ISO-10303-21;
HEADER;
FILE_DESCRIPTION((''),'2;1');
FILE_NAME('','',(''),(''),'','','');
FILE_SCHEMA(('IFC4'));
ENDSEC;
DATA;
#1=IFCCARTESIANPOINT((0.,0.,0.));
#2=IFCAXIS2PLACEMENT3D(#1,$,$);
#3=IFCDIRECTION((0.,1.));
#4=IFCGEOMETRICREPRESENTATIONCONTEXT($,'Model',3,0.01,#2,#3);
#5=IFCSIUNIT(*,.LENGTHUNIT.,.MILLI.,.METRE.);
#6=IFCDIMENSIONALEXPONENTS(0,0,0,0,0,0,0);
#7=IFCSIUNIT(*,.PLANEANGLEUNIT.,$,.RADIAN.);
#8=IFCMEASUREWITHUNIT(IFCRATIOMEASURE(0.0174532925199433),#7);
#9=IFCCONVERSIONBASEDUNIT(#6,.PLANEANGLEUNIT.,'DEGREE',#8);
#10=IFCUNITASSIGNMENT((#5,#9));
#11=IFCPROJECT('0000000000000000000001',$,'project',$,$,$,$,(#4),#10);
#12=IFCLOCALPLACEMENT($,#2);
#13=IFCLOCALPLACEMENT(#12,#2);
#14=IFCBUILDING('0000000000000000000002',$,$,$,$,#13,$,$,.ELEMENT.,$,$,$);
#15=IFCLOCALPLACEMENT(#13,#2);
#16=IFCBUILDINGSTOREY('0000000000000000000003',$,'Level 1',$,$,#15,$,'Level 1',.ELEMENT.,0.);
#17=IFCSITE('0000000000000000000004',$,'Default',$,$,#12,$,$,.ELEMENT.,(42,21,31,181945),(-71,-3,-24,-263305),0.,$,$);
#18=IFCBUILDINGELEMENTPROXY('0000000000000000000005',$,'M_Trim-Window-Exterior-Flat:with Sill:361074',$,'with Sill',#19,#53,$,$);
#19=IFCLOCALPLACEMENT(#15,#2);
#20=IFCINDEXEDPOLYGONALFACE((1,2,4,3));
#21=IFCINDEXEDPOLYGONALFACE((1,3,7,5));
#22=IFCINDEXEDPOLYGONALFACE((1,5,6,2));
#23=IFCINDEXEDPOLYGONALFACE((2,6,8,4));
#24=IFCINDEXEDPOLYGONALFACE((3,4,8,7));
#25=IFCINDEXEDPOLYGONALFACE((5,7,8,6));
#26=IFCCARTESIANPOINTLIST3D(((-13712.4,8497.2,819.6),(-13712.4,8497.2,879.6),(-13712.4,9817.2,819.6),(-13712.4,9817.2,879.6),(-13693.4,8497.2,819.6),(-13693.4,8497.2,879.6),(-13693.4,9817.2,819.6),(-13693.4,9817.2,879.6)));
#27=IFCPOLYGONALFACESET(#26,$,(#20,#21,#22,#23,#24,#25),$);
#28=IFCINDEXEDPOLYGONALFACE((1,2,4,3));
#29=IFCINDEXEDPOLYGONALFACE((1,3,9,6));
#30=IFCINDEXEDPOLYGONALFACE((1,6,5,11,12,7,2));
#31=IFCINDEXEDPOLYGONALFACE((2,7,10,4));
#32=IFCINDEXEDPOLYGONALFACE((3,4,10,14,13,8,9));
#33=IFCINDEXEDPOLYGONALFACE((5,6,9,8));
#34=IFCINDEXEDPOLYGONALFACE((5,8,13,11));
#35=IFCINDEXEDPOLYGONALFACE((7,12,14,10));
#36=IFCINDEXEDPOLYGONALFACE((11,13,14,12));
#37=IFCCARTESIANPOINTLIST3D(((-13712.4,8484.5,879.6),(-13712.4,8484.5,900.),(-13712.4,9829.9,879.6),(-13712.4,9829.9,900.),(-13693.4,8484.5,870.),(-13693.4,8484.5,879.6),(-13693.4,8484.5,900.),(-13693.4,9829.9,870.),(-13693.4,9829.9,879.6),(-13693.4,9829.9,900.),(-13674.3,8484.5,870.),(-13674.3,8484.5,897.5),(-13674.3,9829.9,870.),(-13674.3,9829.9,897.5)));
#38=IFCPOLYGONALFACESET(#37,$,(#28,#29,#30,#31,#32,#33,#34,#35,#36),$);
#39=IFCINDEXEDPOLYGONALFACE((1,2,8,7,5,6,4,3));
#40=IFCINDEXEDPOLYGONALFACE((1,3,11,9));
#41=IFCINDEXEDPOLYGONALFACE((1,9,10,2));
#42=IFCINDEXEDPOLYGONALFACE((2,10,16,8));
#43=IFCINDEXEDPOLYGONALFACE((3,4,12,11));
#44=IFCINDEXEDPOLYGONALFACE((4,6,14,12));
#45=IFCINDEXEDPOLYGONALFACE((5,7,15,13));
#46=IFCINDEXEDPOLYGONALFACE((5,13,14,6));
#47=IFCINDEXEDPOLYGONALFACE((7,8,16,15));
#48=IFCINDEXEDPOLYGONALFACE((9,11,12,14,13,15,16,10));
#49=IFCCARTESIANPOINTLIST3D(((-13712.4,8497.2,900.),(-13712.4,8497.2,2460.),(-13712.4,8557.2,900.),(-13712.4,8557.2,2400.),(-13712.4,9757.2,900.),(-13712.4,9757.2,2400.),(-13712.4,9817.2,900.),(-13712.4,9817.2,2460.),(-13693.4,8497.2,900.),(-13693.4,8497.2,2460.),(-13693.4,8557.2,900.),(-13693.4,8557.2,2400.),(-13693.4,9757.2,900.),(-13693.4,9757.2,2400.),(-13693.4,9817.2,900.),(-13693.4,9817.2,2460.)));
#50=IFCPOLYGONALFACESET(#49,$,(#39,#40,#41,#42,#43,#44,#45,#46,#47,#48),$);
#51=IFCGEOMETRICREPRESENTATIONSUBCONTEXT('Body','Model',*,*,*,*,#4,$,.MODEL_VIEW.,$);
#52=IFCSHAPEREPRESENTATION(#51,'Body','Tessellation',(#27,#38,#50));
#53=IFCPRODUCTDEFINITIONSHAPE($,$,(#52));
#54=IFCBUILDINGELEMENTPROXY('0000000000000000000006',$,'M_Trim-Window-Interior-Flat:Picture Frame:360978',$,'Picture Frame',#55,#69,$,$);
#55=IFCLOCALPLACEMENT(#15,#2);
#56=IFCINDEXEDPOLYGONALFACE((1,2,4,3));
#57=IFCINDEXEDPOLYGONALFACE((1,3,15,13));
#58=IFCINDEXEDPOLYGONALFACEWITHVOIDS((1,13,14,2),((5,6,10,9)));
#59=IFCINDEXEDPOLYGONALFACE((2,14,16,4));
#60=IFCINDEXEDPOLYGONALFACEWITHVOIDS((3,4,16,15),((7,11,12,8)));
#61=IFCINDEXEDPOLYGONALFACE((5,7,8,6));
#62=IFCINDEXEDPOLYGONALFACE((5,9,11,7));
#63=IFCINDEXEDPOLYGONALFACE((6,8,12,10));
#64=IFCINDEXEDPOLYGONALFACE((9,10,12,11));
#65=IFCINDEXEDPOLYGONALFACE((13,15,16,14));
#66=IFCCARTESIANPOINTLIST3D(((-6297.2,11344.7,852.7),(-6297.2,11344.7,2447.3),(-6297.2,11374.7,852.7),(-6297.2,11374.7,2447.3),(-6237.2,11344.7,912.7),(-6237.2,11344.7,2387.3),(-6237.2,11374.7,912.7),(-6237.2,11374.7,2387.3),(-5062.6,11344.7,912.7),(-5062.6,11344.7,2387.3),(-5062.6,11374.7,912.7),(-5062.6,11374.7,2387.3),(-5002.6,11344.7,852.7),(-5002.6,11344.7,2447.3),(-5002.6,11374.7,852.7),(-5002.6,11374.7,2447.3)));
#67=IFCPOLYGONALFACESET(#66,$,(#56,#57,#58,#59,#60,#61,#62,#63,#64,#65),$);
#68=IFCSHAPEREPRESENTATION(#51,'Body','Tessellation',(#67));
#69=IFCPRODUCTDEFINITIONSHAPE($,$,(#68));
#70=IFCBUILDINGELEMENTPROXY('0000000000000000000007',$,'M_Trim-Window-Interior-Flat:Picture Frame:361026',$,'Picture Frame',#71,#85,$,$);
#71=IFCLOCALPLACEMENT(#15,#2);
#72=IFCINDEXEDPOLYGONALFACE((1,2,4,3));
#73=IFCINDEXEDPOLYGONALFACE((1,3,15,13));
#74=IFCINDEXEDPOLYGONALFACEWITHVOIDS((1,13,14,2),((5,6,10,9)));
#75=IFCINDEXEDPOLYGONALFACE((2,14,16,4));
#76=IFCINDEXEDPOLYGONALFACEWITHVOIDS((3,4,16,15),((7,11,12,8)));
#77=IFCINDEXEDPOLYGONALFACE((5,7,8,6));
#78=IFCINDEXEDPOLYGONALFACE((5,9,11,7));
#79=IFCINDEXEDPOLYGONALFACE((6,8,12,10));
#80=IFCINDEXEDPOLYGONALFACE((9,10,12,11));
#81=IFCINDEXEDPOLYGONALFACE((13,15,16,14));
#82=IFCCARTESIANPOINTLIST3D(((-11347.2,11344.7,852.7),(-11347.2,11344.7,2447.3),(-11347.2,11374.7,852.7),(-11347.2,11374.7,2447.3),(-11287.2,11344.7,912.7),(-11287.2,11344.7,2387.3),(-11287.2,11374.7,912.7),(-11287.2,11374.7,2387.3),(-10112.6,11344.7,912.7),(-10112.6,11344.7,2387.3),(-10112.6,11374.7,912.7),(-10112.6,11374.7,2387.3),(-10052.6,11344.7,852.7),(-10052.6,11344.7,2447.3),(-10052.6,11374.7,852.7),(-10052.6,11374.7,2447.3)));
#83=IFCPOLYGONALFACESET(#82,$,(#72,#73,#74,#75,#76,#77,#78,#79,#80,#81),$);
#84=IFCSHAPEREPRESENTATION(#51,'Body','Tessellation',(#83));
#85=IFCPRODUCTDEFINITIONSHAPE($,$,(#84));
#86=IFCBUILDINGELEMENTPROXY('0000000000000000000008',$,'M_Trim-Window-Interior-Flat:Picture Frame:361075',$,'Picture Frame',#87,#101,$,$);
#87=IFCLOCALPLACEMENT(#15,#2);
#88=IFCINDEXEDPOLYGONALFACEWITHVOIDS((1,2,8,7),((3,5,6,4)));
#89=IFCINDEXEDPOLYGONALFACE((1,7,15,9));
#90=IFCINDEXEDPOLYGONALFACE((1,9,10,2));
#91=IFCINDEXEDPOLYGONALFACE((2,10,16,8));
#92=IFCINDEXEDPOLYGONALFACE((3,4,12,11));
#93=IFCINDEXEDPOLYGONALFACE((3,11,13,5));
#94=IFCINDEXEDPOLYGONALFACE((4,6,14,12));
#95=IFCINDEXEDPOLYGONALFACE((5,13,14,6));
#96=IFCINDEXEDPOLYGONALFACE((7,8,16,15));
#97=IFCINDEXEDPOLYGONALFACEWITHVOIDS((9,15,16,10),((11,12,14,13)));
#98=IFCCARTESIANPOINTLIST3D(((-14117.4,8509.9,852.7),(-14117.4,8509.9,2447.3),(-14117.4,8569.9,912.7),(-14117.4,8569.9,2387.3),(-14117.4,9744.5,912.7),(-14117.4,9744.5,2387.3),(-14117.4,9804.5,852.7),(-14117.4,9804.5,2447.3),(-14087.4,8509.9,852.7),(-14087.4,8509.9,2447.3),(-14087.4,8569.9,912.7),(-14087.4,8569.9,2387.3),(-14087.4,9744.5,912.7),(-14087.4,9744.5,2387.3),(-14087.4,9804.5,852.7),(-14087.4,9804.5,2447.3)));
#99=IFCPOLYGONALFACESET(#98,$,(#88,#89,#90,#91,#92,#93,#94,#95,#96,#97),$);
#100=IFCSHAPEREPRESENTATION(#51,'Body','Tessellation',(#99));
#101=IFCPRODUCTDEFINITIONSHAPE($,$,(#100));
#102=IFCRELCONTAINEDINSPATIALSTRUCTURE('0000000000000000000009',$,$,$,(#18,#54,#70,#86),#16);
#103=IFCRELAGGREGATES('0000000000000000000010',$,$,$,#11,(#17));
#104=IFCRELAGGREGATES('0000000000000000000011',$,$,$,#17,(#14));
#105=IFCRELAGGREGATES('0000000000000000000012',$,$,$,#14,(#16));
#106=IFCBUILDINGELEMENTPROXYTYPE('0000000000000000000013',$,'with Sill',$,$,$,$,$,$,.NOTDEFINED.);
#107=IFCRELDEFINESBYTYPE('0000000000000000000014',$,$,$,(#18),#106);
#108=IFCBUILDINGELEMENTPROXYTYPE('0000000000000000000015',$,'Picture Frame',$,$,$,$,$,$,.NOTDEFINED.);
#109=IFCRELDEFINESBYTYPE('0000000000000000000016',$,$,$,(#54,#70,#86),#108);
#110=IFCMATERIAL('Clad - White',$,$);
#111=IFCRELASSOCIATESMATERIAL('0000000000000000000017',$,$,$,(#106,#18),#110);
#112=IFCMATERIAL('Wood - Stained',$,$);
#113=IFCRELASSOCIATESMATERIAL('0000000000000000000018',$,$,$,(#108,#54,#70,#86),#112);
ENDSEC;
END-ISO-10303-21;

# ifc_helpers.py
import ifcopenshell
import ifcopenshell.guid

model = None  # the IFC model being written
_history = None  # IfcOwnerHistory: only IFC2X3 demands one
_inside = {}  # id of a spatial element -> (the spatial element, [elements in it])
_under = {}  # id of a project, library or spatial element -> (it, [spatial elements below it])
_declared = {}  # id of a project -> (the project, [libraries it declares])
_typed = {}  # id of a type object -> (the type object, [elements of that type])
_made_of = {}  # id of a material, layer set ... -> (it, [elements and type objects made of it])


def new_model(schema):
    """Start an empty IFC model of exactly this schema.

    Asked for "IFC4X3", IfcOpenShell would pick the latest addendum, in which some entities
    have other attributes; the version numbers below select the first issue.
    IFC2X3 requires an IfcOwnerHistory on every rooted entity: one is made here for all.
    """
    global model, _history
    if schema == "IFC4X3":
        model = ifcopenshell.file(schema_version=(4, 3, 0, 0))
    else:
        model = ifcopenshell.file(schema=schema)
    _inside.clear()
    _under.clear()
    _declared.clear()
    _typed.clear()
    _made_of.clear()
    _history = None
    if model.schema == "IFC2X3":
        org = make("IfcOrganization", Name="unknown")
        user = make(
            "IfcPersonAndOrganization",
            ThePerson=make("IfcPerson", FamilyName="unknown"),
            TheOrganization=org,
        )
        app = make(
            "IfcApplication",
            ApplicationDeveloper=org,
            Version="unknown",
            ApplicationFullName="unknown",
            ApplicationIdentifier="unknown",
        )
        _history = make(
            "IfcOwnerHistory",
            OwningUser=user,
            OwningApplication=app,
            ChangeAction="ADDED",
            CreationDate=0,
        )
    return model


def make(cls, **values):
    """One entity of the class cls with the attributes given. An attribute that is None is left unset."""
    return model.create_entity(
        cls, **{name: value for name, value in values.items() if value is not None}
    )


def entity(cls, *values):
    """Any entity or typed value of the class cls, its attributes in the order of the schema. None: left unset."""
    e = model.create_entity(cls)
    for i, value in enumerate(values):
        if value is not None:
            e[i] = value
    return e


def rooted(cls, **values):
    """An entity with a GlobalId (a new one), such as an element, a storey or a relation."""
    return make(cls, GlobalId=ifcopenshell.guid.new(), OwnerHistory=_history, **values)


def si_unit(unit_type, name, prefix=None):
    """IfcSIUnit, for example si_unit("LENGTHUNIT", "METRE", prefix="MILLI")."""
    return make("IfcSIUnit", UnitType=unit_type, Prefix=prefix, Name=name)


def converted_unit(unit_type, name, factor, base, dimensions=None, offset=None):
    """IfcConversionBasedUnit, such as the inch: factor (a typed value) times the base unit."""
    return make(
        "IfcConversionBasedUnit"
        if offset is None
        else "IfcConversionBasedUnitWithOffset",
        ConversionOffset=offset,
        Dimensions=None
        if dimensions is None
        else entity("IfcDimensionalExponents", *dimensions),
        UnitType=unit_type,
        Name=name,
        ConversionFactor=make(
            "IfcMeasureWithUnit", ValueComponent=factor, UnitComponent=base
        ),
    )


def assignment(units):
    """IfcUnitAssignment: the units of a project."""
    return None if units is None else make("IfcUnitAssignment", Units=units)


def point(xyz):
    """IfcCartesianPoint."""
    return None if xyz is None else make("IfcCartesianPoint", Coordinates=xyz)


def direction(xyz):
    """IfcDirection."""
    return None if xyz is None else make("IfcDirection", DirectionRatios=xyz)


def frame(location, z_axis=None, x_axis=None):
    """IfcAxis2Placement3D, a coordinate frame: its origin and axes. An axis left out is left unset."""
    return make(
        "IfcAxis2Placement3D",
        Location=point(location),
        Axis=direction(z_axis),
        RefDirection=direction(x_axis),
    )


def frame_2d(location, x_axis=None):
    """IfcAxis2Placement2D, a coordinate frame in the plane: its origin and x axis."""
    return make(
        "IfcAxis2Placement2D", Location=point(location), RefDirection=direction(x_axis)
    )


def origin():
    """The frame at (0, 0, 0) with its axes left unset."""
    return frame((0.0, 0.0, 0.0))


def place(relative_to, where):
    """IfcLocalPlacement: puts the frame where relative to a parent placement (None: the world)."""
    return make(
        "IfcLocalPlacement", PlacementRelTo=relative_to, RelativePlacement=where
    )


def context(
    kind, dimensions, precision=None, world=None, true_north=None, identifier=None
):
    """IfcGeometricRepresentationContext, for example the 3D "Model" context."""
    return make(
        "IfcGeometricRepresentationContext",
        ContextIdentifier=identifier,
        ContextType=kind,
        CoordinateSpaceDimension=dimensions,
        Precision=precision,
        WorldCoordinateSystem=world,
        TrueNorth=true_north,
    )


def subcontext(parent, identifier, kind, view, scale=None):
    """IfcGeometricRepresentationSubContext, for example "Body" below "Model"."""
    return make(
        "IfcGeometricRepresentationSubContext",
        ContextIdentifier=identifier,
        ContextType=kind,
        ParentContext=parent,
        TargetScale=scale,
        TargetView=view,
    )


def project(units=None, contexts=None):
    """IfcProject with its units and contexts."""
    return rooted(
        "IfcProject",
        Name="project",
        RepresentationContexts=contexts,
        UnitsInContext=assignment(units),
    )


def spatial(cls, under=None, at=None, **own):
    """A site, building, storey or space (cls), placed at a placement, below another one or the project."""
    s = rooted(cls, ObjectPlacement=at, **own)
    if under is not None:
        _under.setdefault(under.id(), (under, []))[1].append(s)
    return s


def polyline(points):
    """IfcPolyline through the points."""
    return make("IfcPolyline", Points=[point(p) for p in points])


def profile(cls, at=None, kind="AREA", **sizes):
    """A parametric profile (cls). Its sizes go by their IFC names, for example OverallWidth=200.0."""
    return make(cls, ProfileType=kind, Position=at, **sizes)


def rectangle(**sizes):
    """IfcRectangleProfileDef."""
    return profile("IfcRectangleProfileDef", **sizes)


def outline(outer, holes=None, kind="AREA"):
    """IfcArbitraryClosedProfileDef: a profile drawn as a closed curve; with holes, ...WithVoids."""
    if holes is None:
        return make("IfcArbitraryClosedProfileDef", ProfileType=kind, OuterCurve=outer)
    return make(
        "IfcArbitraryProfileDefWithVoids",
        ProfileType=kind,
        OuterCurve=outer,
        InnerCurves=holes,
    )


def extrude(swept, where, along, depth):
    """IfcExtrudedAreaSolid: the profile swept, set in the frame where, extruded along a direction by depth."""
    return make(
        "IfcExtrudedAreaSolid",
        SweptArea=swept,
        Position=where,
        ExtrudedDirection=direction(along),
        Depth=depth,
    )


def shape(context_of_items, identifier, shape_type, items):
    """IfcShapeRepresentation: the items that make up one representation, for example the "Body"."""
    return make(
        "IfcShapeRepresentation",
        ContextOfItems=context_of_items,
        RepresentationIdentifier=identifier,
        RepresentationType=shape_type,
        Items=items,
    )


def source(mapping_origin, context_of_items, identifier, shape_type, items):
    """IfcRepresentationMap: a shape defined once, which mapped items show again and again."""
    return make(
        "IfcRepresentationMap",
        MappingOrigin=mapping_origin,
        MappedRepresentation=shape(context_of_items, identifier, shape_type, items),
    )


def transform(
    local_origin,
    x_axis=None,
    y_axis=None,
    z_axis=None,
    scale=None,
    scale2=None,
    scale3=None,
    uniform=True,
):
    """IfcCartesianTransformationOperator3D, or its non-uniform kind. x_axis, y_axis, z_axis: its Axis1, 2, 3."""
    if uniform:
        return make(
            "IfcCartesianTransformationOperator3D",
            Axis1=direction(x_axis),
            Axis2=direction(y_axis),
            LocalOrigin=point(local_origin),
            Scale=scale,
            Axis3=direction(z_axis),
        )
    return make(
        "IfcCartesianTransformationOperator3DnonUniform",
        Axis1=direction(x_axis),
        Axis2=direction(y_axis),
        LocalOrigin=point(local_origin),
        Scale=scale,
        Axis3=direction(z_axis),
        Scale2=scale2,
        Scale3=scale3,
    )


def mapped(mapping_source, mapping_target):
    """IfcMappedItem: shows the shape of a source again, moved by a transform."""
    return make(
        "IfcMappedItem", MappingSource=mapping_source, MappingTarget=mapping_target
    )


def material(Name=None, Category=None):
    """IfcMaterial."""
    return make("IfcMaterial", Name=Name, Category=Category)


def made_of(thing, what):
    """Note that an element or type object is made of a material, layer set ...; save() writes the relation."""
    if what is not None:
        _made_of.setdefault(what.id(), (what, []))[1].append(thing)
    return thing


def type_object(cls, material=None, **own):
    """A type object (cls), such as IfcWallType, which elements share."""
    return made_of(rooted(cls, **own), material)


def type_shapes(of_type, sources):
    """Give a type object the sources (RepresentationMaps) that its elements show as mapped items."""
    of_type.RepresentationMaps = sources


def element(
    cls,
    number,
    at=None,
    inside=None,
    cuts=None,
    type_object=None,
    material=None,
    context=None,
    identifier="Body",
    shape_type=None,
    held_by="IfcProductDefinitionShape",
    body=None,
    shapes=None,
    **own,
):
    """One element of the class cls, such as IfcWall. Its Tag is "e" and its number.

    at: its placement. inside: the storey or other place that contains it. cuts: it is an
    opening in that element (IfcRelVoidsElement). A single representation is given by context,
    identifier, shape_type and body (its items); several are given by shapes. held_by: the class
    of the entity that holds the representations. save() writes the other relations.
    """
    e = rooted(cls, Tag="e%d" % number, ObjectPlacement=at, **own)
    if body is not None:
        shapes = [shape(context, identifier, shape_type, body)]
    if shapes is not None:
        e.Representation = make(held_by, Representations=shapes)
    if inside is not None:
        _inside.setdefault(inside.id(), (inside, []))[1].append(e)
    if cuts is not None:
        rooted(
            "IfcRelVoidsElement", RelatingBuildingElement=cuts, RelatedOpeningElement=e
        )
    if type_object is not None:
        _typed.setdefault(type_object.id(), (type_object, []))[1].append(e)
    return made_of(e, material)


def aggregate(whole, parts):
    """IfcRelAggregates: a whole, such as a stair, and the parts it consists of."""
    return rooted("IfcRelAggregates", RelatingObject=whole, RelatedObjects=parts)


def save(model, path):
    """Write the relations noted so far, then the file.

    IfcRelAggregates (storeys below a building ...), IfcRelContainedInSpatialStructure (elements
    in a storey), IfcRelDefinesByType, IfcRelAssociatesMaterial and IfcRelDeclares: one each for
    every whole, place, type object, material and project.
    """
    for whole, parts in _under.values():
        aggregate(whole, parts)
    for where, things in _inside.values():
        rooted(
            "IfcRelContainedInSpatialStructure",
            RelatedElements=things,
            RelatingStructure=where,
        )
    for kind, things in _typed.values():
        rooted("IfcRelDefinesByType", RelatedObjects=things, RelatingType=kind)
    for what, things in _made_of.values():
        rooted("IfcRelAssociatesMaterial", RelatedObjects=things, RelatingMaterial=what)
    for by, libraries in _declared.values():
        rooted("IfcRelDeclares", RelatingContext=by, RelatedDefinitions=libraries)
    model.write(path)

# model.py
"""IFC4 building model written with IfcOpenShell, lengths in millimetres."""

from ifc_helpers import new_model, entity, si_unit, converted_unit, direction, frame, frame_2d, origin, place, context, subcontext, project, spatial, polyline, rectangle, outline, extrude, source, transform, mapped, material, type_object, type_shapes, element, save


model = new_model("IFC4")

# Units and contexts
model_context = context("Model", 3, precision=0.01, world=origin(), true_north=direction((0.0, 1.0)))
body_context = subcontext(model_context, "Body", "Model", "MODEL_VIEW")
ifc_project = project(units=[si_unit("LENGTHUNIT", "METRE", prefix="MILLI"), converted_unit("PLANEANGLEUNIT", "DEGREE", entity("IfcRatioMeasure", 0.0174532925199433), si_unit("PLANEANGLEUNIT", "RADIAN"), dimensions=[0, 0, 0, 0, 0, 0, 0])], contexts=[model_context])

# Site, building, storey
site_placement = place(None, origin())
site = spatial("IfcSite", under=ifc_project, at=site_placement, Name="Default", CompositionType="ELEMENT", RefLatitude=(42, 21, 31, 181945), RefLongitude=(-71, -3, -24, -263305), RefElevation=0.0)
building_placement = place(site_placement, origin())
building = spatial("IfcBuilding", under=site, at=building_placement, CompositionType="ELEMENT")
storey_placement = place(building_placement, origin())
storey = spatial("IfcBuildingStorey", under=building, at=storey_placement, Name="Level 1", LongName="Level 1", CompositionType="ELEMENT", Elevation=0.0)

# Building element proxies
ifc_material_1 = material(Name="Clad - White")
ifc_material_2 = material(Name="Wood - Stained")
building_element_proxy_type_1 = type_object("IfcBuildingElementProxyType", Name="with Sill", PredefinedType="NOTDEFINED", material=ifc_material_1)
shared_shape_1 = source(origin(), body_context, "Body", "SweptSolid", [
    extrude(rectangle(XDim=1320.0, YDim=60.0, at=frame_2d((0.0, 0.0), x_axis=(1.0, 0.0))), frame((0.0, -1550.4, 0.0), z_axis=(0.0, 0.0, 1.0), x_axis=(-1.0, 0.0, 0.0)), (0.0, 0.0, 1.0), 19.1),
    extrude(outline(polyline([(-19.0, -15.2), (0.0, -15.2), (0.0, -5.7), (19.0, -5.7), (19.0, 14.8), (0.0, 14.8), (-19.0, 12.3), (-19.0, -15.2)])), frame((-672.7, -1514.8, 19.0), z_axis=(1.0, 0.0, 0.0), x_axis=(0.0, 0.0, -1.0)), (0.0, 0.0, 1.0), 1345.4),
    extrude(outline(polyline([(-795.0, -660.0), (765.0, -660.0), (765.0, -600.0), (-735.0, -600.0), (-735.0, 600.0), (765.0, 600.0), (765.0, 660.0), (-795.0, 660.0), (-795.0, -660.0)])), frame((0.0, -735.0, 0.0), z_axis=(0.0, 0.0, 1.0), x_axis=(0.0, -1.0, 0.0)), (0.0, 0.0, 1.0), 19.1),
])
type_shapes(building_element_proxy_type_1, [shared_shape_1])
for number, where, z_axis, x_axis, name in (
    (1, (-13712.4, 9157.2, 2400.0), (1.0, 0.0, 0.0), (0.0, 1.0, 0.0), "M_Trim-Window-Exterior-Flat:with Sill:361074"),
):
    element("IfcBuildingElementProxy", number, at=place(storey_placement, frame(where, z_axis=z_axis, x_axis=x_axis)), inside=storey, type_object=building_element_proxy_type_1, material=ifc_material_1, Name=name, ObjectType="with Sill", context=body_context, shape_type="MappedRepresentation", body=[
        mapped(shared_shape_1, transform((0.0, 0.0, 0.0), scale=1.0)),
    ])
building_element_proxy_type_2 = type_object("IfcBuildingElementProxyType", Name="Picture Frame", PredefinedType="NOTDEFINED", material=ifc_material_2)
shared_shape_2 = source(origin(), body_context, "Body", "SweptSolid", [
    extrude(outline(polyline([(-647.3, -797.3), (647.3, -797.3), (647.3, 797.3), (-647.3, 797.3), (-647.3, -797.3)]), holes=[polyline([(-587.3, -737.3), (-587.3, 737.3), (587.3, 737.3), (587.3, -737.3), (-587.3, -737.3)])]), frame((0.0, -750.0, 0.0), z_axis=(0.0, 0.0, 1.0), x_axis=(-1.0, 0.0, 0.0)), (0.0, 0.0, 1.0), 30.0),
])
type_shapes(building_element_proxy_type_2, [shared_shape_2])
for number, where, z_axis, x_axis, name in (
    (2, (-5649.9, 11344.7, 2400.0), (0.0, 1.0, 0.0), (-1.0, 0.0, 0.0), "M_Trim-Window-Interior-Flat:Picture Frame:360978"),
    (3, (-10699.9, 11344.7, 2400.0), (0.0, 1.0, 0.0), (-1.0, 0.0, 0.0), "M_Trim-Window-Interior-Flat:Picture Frame:361026"),
    (4, (-14087.4, 9157.2, 2400.0), (-1.0, 0.0, 0.0), (0.0, -1.0, 0.0), "M_Trim-Window-Interior-Flat:Picture Frame:361075"),
):
    element("IfcBuildingElementProxy", number, at=place(storey_placement, frame(where, z_axis=z_axis, x_axis=x_axis)), inside=storey, type_object=building_element_proxy_type_2, material=ifc_material_2, Name=name, ObjectType="Picture Frame", context=body_context, shape_type="MappedRepresentation", body=[
        mapped(shared_shape_2, transform((0.0, 0.0, 0.0), scale=1.0)),
    ])

save(model, "model.ifc")
